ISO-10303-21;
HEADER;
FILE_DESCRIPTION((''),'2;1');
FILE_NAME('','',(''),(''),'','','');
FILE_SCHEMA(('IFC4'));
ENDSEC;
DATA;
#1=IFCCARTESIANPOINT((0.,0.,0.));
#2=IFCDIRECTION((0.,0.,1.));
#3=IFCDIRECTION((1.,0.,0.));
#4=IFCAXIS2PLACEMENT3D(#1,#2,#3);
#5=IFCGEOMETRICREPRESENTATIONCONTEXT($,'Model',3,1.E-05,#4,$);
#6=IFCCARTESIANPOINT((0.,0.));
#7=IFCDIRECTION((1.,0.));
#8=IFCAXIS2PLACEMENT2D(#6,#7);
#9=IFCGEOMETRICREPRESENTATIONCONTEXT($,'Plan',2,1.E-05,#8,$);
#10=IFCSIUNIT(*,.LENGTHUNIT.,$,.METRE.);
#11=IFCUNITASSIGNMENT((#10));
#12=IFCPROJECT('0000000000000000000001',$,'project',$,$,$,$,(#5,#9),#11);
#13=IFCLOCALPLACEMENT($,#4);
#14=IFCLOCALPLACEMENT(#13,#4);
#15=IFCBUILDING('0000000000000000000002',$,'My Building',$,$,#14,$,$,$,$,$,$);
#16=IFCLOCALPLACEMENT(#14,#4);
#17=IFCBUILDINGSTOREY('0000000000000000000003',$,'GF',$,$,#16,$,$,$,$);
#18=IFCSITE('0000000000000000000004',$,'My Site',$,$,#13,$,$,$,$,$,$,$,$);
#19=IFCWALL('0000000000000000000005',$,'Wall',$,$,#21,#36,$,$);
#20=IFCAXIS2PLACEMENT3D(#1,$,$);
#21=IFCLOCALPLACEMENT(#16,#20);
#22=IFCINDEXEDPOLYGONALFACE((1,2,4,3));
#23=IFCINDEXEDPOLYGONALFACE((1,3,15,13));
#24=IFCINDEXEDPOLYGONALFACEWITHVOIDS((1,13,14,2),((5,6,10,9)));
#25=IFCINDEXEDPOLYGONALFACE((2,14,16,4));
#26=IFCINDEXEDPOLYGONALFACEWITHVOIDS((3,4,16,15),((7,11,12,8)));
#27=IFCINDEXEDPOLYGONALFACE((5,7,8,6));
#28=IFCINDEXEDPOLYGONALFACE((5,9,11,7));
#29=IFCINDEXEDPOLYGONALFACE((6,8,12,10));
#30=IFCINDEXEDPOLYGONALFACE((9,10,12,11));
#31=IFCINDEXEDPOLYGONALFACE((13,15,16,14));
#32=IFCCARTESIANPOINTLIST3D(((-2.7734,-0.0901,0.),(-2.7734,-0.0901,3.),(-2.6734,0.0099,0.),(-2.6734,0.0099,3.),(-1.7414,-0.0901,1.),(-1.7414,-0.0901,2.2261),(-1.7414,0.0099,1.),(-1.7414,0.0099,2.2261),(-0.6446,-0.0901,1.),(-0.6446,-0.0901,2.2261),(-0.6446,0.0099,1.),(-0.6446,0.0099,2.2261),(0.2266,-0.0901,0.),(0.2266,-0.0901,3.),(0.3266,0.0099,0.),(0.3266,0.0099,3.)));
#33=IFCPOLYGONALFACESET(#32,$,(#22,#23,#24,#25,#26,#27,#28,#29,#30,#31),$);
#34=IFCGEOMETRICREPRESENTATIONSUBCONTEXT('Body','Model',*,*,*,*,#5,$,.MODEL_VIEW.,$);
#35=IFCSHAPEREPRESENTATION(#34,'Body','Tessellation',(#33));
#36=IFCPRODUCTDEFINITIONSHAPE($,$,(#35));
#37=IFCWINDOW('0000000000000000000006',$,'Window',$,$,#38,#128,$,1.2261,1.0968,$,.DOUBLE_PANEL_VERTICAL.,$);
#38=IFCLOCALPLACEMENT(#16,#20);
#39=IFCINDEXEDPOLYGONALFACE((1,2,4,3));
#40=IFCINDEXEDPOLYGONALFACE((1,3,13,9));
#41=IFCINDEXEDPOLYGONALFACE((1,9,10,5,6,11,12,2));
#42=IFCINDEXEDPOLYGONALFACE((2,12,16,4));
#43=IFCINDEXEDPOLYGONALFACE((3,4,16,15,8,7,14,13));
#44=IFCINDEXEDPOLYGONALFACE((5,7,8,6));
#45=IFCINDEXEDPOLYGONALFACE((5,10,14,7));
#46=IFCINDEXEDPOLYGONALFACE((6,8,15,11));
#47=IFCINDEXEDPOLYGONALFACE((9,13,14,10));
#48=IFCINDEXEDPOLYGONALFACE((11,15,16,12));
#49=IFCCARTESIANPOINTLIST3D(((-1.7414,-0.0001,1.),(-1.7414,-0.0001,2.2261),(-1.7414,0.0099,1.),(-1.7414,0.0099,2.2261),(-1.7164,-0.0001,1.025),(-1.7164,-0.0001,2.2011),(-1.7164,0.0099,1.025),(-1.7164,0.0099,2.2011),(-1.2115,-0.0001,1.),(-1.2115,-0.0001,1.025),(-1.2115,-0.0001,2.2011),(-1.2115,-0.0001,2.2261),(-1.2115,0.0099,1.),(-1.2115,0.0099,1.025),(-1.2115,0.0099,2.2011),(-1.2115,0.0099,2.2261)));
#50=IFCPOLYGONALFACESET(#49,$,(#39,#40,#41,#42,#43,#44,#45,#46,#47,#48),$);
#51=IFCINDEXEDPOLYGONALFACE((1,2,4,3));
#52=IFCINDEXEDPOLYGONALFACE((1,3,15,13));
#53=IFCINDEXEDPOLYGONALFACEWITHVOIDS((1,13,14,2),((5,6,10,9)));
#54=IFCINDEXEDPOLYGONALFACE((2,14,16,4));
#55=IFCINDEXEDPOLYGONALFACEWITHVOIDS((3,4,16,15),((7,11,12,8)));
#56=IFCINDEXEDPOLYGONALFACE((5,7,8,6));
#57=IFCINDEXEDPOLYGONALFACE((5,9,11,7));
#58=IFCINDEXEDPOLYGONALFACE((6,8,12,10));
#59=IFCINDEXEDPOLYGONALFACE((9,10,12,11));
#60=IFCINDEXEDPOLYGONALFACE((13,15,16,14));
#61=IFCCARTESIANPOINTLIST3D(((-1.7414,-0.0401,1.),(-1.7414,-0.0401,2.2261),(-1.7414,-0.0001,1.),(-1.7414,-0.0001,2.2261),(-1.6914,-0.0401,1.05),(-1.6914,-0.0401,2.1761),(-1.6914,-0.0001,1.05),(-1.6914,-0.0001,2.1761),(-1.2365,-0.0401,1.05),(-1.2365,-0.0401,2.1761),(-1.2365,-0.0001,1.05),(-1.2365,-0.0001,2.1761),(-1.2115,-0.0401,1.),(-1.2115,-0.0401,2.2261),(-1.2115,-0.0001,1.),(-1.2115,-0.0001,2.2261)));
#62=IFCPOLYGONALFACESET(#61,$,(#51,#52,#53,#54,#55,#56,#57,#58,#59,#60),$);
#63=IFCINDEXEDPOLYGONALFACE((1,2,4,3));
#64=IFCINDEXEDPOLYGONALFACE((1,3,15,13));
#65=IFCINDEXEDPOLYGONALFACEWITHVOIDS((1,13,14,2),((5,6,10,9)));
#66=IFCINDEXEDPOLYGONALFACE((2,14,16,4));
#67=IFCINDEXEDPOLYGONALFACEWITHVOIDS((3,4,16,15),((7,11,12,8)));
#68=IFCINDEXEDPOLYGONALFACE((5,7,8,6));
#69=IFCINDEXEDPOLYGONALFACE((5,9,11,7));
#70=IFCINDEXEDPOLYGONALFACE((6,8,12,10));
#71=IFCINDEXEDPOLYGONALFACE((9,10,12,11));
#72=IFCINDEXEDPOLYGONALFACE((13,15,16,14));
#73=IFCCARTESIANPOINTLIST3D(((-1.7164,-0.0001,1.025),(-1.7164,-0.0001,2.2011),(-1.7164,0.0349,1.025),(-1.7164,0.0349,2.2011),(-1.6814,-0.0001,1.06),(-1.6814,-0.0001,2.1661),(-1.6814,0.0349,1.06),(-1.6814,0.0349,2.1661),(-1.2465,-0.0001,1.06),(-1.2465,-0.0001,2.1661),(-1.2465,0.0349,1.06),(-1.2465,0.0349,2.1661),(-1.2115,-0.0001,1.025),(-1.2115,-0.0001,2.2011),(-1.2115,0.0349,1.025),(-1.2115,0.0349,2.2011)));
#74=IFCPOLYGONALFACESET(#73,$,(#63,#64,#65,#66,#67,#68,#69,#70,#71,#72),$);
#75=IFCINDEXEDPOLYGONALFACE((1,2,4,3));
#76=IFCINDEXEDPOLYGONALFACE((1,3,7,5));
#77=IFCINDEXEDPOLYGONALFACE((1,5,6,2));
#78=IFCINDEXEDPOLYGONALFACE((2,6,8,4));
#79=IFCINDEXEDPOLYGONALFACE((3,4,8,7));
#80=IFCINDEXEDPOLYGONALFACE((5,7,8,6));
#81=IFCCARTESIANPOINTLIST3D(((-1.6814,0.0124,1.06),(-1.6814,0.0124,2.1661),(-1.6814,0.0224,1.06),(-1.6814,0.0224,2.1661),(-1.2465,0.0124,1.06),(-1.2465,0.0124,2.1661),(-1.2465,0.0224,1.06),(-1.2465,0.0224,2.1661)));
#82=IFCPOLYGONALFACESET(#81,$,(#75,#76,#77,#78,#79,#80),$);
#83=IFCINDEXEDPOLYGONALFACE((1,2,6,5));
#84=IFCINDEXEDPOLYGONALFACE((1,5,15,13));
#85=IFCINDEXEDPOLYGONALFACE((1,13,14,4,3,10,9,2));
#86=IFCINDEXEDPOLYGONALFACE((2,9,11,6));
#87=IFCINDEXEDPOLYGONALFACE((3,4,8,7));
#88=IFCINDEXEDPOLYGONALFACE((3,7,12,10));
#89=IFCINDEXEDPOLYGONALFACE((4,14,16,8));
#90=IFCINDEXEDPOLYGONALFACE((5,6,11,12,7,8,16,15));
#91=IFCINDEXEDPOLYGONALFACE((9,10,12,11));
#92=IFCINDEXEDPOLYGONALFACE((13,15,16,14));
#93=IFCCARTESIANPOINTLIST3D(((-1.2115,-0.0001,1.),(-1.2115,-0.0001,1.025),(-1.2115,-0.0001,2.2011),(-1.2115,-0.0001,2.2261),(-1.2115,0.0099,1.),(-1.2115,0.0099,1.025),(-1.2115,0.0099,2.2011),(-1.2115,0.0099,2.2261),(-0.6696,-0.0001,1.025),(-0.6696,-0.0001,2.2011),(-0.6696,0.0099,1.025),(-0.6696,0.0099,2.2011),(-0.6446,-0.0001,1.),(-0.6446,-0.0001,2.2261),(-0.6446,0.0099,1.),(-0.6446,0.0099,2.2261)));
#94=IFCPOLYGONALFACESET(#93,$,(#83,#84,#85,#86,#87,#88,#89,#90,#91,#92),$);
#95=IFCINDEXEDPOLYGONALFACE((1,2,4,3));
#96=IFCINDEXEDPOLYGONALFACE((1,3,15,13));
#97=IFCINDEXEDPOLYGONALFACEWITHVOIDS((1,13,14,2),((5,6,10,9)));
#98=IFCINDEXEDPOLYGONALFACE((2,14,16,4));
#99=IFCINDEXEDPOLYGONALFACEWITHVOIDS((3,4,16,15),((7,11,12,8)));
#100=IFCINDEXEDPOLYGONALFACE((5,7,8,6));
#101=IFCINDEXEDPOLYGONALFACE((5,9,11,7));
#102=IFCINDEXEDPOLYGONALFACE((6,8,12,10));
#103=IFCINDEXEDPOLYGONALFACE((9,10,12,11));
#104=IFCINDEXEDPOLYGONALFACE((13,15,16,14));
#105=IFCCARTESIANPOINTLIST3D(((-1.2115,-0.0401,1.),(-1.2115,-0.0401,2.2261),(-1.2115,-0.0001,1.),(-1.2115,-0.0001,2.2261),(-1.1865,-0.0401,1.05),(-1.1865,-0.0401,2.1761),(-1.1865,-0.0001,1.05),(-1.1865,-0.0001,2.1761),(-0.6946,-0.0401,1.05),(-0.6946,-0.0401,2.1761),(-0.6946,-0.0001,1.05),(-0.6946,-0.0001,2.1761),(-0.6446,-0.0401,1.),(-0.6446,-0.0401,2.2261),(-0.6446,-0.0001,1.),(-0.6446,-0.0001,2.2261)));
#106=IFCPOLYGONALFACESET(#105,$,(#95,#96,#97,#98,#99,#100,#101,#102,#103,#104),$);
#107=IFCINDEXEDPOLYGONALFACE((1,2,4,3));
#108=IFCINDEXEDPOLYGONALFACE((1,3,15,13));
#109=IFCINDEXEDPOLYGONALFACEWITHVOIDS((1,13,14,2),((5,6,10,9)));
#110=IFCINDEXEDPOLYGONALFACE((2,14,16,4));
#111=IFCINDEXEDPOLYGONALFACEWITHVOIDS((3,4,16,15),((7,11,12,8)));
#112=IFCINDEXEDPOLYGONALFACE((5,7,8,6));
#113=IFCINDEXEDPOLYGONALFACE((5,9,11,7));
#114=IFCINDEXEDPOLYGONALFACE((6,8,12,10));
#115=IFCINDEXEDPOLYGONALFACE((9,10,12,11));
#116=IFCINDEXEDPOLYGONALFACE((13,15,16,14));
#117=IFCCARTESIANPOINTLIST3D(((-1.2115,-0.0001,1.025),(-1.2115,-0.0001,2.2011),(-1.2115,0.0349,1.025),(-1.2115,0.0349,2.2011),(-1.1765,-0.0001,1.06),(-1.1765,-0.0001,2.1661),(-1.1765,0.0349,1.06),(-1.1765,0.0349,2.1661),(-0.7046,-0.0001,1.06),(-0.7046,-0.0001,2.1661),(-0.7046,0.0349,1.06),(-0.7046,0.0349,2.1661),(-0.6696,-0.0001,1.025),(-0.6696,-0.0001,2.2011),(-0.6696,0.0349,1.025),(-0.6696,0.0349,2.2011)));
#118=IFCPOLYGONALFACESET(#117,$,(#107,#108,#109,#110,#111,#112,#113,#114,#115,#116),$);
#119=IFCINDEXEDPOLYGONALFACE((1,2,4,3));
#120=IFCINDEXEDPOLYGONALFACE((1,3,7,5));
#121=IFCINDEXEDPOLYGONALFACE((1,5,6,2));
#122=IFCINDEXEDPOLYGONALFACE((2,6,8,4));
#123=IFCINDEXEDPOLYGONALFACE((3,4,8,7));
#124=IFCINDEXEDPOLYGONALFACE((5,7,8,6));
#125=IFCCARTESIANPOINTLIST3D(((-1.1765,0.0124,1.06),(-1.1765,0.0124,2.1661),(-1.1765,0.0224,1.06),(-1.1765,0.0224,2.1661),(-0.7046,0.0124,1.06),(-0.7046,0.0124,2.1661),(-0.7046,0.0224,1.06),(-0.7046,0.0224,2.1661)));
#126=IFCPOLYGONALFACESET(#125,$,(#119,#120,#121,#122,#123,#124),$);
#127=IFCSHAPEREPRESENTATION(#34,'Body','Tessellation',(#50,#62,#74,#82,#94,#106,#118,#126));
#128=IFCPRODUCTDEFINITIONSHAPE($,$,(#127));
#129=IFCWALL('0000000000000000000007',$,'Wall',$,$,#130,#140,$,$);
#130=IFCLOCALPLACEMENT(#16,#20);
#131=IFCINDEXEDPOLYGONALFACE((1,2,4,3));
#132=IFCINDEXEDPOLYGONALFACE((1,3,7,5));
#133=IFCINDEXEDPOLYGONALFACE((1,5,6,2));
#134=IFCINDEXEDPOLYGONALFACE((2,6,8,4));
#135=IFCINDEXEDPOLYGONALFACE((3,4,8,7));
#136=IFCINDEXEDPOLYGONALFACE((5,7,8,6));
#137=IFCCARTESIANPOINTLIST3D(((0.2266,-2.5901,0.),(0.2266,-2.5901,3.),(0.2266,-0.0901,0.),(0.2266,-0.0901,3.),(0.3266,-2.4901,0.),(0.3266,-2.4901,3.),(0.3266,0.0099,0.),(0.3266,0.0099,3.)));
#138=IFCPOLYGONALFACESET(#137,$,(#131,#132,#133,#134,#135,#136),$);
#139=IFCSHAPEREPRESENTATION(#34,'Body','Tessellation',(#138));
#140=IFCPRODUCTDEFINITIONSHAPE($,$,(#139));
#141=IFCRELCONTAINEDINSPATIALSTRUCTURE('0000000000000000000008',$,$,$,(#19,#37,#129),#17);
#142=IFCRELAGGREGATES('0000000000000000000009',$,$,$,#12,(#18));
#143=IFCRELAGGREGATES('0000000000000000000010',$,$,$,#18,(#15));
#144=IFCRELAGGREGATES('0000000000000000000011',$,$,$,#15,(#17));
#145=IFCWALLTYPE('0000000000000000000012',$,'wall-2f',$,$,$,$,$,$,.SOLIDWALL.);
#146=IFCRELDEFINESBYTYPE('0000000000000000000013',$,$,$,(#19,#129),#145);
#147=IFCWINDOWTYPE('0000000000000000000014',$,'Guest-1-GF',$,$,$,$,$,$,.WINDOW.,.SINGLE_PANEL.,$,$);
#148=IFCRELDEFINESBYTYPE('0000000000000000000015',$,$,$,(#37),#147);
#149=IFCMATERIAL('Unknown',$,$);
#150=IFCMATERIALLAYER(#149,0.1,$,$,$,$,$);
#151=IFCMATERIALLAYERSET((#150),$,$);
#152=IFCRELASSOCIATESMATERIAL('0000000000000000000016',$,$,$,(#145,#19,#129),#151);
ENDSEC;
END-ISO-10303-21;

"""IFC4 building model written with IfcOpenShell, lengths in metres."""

from ifc_helpers import new_model, entity, si_unit, frame, origin_with_axes, origin_2d_with_axis, place, context, subcontext, project, spatial, line, indexed_curve, outline, extrude, shape, source, transform, mapped, material, layer, layer_set, layer_usage, type_object, type_shapes, element, fill, save


model = new_model("IFC4")

# Units and contexts
model_context = context("Model", 3, precision=1e-05, world=origin_with_axes())
plan_context = context("Plan", 2, precision=1e-05, world=origin_2d_with_axis())
body_context_1 = subcontext(model_context, "Body", "Model", "MODEL_VIEW")
body_context_2 = subcontext(plan_context, "Body", "Plan", "PLAN_VIEW")
ifc_project = project(units=[si_unit("LENGTHUNIT", "METRE")], contexts=[model_context, plan_context])

# Site, building, storey
site_placement = place(None, origin_with_axes())
site = spatial("IfcSite", under=ifc_project, at=site_placement, Name="My Site")
building_placement = place(site_placement, origin_with_axes())
building = spatial("IfcBuilding", under=site, at=building_placement, Name="My Building")
storey_placement = place(building_placement, origin_with_axes())
storey = spatial("IfcBuildingStorey", under=building, at=storey_placement, Name="GF")

# Shared definitions
ifc_material = material(Name="Unknown")

# Shared definitions
ifc_layer_1 = layer(ifc_material, 0.1)
ifc_layer_set_1 = layer_set([ifc_layer_1])
wall_type = type_object("IfcWallType", Name="wall-2f", PredefinedType="SOLIDWALL", material=ifc_layer_set_1)

# Wall, opening, window
ifc_layer_usage_1 = layer_usage(ifc_layer_set_1, "AXIS2", "POSITIVE", 0.0)
wall_1_placement = place(storey_placement, frame((-2.7734, -0.0901, 0.0), z_axis=(0.0, 0.0, 1.0), x_axis=(1.0, 0.0, 0.0)))
wall_1 = element("IfcWall", 1, at=wall_1_placement, inside=storey, type_object=wall_type, material=ifc_layer_usage_1, Name="Wall", context=body_context_1, shape_type="SweptSolid", body=[
    extrude(outline(indexed_curve([(0.0, 0.0), (0.1, 0.1), (3.1, 0.1), (3.0, 0.0)], segments=[line(1, 2, 3, 4, 1)])), origin_with_axes(), (0.0, 0.0, 1.0), 3.0),
])
shared_shape_1 = source(origin_with_axes(), body_context_1, "Body", "SweptSolid", [
    extrude(outline(indexed_curve([(0.0, 0.0), (1.0968, 0.0), (1.0968, 1.2261), (0.0, 1.2261)], segments=[line(1, 2, 3, 4, 1)])), frame((0.0, -0.6, 0.0), z_axis=(0.0, -1.0, 0.0), x_axis=(1.0, 0.0, 0.0)), (0.0, 0.0, -1.0), 1.2),
])
opening_1_placement = place(wall_1_placement, frame((1.032, 0.0, 1.0), z_axis=(0.0, 0.0, 1.0), x_axis=(1.0, 0.0, 0.0)))
opening_1 = element("IfcOpeningElement", 2, at=opening_1_placement, cuts=wall_1, PredefinedType="OPENING", context=body_context_1, shape_type="MappedRepresentation", body=[
    mapped(shared_shape_1, transform((0.0, 0.0, 0.0), x_axis=(1.0, 0.0, 0.0), y_axis=(0.0, 1.0, 0.0), z_axis=(0.0, 0.0, 1.0), scale=1.0)),
])
window_type_1 = type_object("IfcWindowType", Name="Guest-1-GF", PartitioningType="SINGLE_PANEL", PredefinedType="WINDOW")
shared_shape_2 = source(origin_with_axes(), body_context_1, "Body", "SweptSolid", [
    extrude(outline(indexed_curve([(0.5299, 0.0), (0.0, 0.0), (0.0, 1.2261), (0.5299, 1.2261), (0.5299, 1.2011), (0.025, 1.2011), (0.025, 0.025), (0.5299, 0.025)], segments=[line(1, 2, 3, 4, 5, 6, 7, 8, 1)])), frame((0.0, 0.09, 0.0), z_axis=(0.0, -1.0, 0.0), x_axis=(1.0, 0.0, 0.0)), (0.0, 0.0, -1.0), 0.01),
    extrude(outline(indexed_curve([(0.0, 0.0), (0.5299, 0.0), (0.5299, 1.2261), (0.0, 1.2261)], segments=[line(1, 2, 3, 4, 1)]), holes=[indexed_curve([(0.05, 0.05), (0.5049, 0.05), (0.5049, 1.1761), (0.05, 1.1761)], segments=[line(1, 2, 3, 4, 1)])]), frame((0.0, 0.05, 0.0), z_axis=(0.0, -1.0, 0.0), x_axis=(1.0, 0.0, 0.0)), (0.0, 0.0, -1.0), 0.04),
    extrude(outline(indexed_curve([(0.0, 0.0), (0.5049, 0.0), (0.5049, 1.1761), (0.0, 1.1761)], segments=[line(1, 2, 3, 4, 1)]), holes=[indexed_curve([(0.035, 0.035), (0.4699, 0.035), (0.4699, 1.1411), (0.035, 1.1411)], segments=[line(1, 2, 3, 4, 1)])]), frame((0.025, 0.09, 0.025), z_axis=(0.0, -1.0, 0.0), x_axis=(1.0, 0.0, 0.0)), (0.0, 0.0, -1.0), 0.035),
    extrude(outline(indexed_curve([(0.035, 0.035), (0.4699, 0.035), (0.4699, 1.1411), (0.035, 1.1411)], segments=[line(1, 2, 3, 4, 1)])), frame((0.025, 0.1025, 0.025), z_axis=(0.0, -1.0, 0.0), x_axis=(1.0, 0.0, 0.0)), (0.0, 0.0, -1.0), 0.01),
    extrude(outline(indexed_curve([(0.0, 1.2261), (0.5669, 1.2261), (0.5669, 0.0), (0.0, 0.0), (0.0, 0.025), (0.5419, 0.025), (0.5419, 1.2011), (0.0, 1.2011)], segments=[line(1, 2, 3, 4, 5, 6, 7, 8, 1)])), frame((0.5299, 0.09, 0.0), z_axis=(0.0, -1.0, 0.0), x_axis=(1.0, 0.0, 0.0)), (0.0, 0.0, -1.0), 0.01),
    extrude(outline(indexed_curve([(0.0, 0.0), (0.5669, 0.0), (0.5669, 1.2261), (0.0, 1.2261)], segments=[line(1, 2, 3, 4, 1)]), holes=[indexed_curve([(0.025, 0.05), (0.5169, 0.05), (0.5169, 1.1761), (0.025, 1.1761)], segments=[line(1, 2, 3, 4, 1)])]), frame((0.5299, 0.05, 0.0), z_axis=(0.0, -1.0, 0.0), x_axis=(1.0, 0.0, 0.0)), (0.0, 0.0, -1.0), 0.04),
    extrude(outline(indexed_curve([(0.0, 0.0), (0.5419, 0.0), (0.5419, 1.1761), (0.0, 1.1761)], segments=[line(1, 2, 3, 4, 1)]), holes=[indexed_curve([(0.035, 0.035), (0.5069, 0.035), (0.5069, 1.1411), (0.035, 1.1411)], segments=[line(1, 2, 3, 4, 1)])]), frame((0.5299, 0.09, 0.025), z_axis=(0.0, -1.0, 0.0), x_axis=(1.0, 0.0, 0.0)), (0.0, 0.0, -1.0), 0.035),
    extrude(outline(indexed_curve([(0.035, 0.035), (0.5069, 0.035), (0.5069, 1.1411), (0.035, 1.1411)], segments=[line(1, 2, 3, 4, 1)])), frame((0.5299, 0.1025, 0.025), z_axis=(0.0, -1.0, 0.0), x_axis=(1.0, 0.0, 0.0)), (0.0, 0.0, -1.0), 0.01),
])
shared_shape_3 = source(origin_with_axes(), body_context_2, "Body", "Curve2D", [
    entity("IfcIndexedPolyCurve", entity("IfcCartesianPointList2D", [[0.05, 0.05], [0.5049, 0.05]])),
    entity("IfcIndexedPolyCurve", entity("IfcCartesianPointList2D", [[0.0, 0.1], [0.025, 0.1], [0.025, 0.09], [0.05, 0.09], [0.05, 0.05], [0.0, 0.05]]), [entity("IfcLineIndex", [1, 2, 3, 4, 5, 6, 1])]),
    entity("IfcIndexedPolyCurve", entity("IfcCartesianPointList2D", [[0.5299, 0.1], [0.5299, 0.1], [0.5299, 0.09], [0.5049, 0.09], [0.5049, 0.05], [0.5299, 0.05]])),
    entity("IfcIndexedPolyCurve", entity("IfcCartesianPointList2D", [[0.025, 0.09], [0.06, 0.09], [0.06, 0.125], [0.025, 0.125]]), [entity("IfcLineIndex", [1, 2, 3, 4, 1])]),
    entity("IfcIndexedPolyCurve", entity("IfcCartesianPointList2D", [[0.5299, 0.09], [0.4949, 0.09], [0.4949, 0.125], [0.5299, 0.125]]), [entity("IfcLineIndex", [1, 2, 3, 4, 1])]),
    entity("IfcIndexedPolyCurve", entity("IfcCartesianPointList2D", [[0.06, 0.09], [0.4949, 0.09]])),
    entity("IfcIndexedPolyCurve", entity("IfcCartesianPointList2D", [[0.06, 0.125], [0.4949, 0.125]])),
    entity("IfcIndexedPolyCurve", entity("IfcCartesianPointList2D", [[0.06, 0.1075], [0.4949, 0.1075]])),
    entity("IfcIndexedPolyCurve", entity("IfcCartesianPointList2D", [[0.5549, 0.05], [1.0468, 0.05]])),
    entity("IfcIndexedPolyCurve", entity("IfcCartesianPointList2D", [[0.5299, 0.1], [0.5299, 0.1], [0.5299, 0.09], [0.5549, 0.09], [0.5549, 0.05], [0.5299, 0.05]])),
    entity("IfcIndexedPolyCurve", entity("IfcCartesianPointList2D", [[1.0968, 0.1], [1.0718, 0.1], [1.0718, 0.09], [1.0468, 0.09], [1.0468, 0.05], [1.0968, 0.05]]), [entity("IfcLineIndex", [1, 2, 3, 4, 5, 6, 1])]),
    entity("IfcIndexedPolyCurve", entity("IfcCartesianPointList2D", [[0.5299, 0.09], [0.5649, 0.09], [0.5649, 0.125], [0.5299, 0.125]]), [entity("IfcLineIndex", [1, 2, 3, 4, 1])]),
    entity("IfcIndexedPolyCurve", entity("IfcCartesianPointList2D", [[1.0718, 0.09], [1.0368, 0.09], [1.0368, 0.125], [1.0718, 0.125]]), [entity("IfcLineIndex", [1, 2, 3, 4, 1])]),
    entity("IfcIndexedPolyCurve", entity("IfcCartesianPointList2D", [[0.5649, 0.09], [1.0368, 0.09]])),
    entity("IfcIndexedPolyCurve", entity("IfcCartesianPointList2D", [[0.5649, 0.125], [1.0368, 0.125]])),
    entity("IfcIndexedPolyCurve", entity("IfcCartesianPointList2D", [[0.5649, 0.1075], [1.0368, 0.1075]])),
])
type_shapes(window_type_1, [shared_shape_2, shared_shape_3])
window_1_placement = place(opening_1_placement, origin_with_axes())
window_1 = element("IfcWindow", 3, at=window_1_placement, inside=storey, type_object=window_type_1, Name="Window", OverallHeight=1.2261, OverallWidth=1.0968, PartitioningType="DOUBLE_PANEL_VERTICAL", shapes=[
    shape(body_context_1, "Body", "MappedRepresentation", [mapped(shared_shape_2, transform((0.0, 0.0, 0.0), x_axis=(1.0, 0.0, 0.0), y_axis=(0.0, 1.0, 0.0), z_axis=(0.0, 0.0, 1.0), scale=1.0))]),
    shape(body_context_2, "Body", "MappedRepresentation", [mapped(shared_shape_3, transform((0.0, 0.0, 0.0), x_axis=(1.0, 0.0, 0.0), y_axis=(0.0, 1.0, 0.0), z_axis=(0.0, 0.0, 1.0), scale=1.0))]),
])
fill(opening_1, window_1)

# Wall
ifc_layer_usage_2 = layer_usage(ifc_layer_set_1, "AXIS2", "POSITIVE", 0.0)
wall_2_placement = place(storey_placement, frame((0.2266, -0.0901, 0.0), z_axis=(0.0, 0.0, 1.0), x_axis=(-0.000001, -1.0, 0.0)))
element("IfcWall", 4, at=wall_2_placement, inside=storey, type_object=wall_type, material=ifc_layer_usage_2, Name="Wall", context=body_context_1, shape_type="SweptSolid", body=[
    extrude(outline(indexed_curve([(0.0, 0.0), (-0.1, 0.1), (2.4, 0.1), (2.5, 0.0)], segments=[line(1, 2, 3, 4, 1)])), origin_with_axes(), (0.0, 0.0, 1.0), 3.0),
])

save(model, "model.ifc")
